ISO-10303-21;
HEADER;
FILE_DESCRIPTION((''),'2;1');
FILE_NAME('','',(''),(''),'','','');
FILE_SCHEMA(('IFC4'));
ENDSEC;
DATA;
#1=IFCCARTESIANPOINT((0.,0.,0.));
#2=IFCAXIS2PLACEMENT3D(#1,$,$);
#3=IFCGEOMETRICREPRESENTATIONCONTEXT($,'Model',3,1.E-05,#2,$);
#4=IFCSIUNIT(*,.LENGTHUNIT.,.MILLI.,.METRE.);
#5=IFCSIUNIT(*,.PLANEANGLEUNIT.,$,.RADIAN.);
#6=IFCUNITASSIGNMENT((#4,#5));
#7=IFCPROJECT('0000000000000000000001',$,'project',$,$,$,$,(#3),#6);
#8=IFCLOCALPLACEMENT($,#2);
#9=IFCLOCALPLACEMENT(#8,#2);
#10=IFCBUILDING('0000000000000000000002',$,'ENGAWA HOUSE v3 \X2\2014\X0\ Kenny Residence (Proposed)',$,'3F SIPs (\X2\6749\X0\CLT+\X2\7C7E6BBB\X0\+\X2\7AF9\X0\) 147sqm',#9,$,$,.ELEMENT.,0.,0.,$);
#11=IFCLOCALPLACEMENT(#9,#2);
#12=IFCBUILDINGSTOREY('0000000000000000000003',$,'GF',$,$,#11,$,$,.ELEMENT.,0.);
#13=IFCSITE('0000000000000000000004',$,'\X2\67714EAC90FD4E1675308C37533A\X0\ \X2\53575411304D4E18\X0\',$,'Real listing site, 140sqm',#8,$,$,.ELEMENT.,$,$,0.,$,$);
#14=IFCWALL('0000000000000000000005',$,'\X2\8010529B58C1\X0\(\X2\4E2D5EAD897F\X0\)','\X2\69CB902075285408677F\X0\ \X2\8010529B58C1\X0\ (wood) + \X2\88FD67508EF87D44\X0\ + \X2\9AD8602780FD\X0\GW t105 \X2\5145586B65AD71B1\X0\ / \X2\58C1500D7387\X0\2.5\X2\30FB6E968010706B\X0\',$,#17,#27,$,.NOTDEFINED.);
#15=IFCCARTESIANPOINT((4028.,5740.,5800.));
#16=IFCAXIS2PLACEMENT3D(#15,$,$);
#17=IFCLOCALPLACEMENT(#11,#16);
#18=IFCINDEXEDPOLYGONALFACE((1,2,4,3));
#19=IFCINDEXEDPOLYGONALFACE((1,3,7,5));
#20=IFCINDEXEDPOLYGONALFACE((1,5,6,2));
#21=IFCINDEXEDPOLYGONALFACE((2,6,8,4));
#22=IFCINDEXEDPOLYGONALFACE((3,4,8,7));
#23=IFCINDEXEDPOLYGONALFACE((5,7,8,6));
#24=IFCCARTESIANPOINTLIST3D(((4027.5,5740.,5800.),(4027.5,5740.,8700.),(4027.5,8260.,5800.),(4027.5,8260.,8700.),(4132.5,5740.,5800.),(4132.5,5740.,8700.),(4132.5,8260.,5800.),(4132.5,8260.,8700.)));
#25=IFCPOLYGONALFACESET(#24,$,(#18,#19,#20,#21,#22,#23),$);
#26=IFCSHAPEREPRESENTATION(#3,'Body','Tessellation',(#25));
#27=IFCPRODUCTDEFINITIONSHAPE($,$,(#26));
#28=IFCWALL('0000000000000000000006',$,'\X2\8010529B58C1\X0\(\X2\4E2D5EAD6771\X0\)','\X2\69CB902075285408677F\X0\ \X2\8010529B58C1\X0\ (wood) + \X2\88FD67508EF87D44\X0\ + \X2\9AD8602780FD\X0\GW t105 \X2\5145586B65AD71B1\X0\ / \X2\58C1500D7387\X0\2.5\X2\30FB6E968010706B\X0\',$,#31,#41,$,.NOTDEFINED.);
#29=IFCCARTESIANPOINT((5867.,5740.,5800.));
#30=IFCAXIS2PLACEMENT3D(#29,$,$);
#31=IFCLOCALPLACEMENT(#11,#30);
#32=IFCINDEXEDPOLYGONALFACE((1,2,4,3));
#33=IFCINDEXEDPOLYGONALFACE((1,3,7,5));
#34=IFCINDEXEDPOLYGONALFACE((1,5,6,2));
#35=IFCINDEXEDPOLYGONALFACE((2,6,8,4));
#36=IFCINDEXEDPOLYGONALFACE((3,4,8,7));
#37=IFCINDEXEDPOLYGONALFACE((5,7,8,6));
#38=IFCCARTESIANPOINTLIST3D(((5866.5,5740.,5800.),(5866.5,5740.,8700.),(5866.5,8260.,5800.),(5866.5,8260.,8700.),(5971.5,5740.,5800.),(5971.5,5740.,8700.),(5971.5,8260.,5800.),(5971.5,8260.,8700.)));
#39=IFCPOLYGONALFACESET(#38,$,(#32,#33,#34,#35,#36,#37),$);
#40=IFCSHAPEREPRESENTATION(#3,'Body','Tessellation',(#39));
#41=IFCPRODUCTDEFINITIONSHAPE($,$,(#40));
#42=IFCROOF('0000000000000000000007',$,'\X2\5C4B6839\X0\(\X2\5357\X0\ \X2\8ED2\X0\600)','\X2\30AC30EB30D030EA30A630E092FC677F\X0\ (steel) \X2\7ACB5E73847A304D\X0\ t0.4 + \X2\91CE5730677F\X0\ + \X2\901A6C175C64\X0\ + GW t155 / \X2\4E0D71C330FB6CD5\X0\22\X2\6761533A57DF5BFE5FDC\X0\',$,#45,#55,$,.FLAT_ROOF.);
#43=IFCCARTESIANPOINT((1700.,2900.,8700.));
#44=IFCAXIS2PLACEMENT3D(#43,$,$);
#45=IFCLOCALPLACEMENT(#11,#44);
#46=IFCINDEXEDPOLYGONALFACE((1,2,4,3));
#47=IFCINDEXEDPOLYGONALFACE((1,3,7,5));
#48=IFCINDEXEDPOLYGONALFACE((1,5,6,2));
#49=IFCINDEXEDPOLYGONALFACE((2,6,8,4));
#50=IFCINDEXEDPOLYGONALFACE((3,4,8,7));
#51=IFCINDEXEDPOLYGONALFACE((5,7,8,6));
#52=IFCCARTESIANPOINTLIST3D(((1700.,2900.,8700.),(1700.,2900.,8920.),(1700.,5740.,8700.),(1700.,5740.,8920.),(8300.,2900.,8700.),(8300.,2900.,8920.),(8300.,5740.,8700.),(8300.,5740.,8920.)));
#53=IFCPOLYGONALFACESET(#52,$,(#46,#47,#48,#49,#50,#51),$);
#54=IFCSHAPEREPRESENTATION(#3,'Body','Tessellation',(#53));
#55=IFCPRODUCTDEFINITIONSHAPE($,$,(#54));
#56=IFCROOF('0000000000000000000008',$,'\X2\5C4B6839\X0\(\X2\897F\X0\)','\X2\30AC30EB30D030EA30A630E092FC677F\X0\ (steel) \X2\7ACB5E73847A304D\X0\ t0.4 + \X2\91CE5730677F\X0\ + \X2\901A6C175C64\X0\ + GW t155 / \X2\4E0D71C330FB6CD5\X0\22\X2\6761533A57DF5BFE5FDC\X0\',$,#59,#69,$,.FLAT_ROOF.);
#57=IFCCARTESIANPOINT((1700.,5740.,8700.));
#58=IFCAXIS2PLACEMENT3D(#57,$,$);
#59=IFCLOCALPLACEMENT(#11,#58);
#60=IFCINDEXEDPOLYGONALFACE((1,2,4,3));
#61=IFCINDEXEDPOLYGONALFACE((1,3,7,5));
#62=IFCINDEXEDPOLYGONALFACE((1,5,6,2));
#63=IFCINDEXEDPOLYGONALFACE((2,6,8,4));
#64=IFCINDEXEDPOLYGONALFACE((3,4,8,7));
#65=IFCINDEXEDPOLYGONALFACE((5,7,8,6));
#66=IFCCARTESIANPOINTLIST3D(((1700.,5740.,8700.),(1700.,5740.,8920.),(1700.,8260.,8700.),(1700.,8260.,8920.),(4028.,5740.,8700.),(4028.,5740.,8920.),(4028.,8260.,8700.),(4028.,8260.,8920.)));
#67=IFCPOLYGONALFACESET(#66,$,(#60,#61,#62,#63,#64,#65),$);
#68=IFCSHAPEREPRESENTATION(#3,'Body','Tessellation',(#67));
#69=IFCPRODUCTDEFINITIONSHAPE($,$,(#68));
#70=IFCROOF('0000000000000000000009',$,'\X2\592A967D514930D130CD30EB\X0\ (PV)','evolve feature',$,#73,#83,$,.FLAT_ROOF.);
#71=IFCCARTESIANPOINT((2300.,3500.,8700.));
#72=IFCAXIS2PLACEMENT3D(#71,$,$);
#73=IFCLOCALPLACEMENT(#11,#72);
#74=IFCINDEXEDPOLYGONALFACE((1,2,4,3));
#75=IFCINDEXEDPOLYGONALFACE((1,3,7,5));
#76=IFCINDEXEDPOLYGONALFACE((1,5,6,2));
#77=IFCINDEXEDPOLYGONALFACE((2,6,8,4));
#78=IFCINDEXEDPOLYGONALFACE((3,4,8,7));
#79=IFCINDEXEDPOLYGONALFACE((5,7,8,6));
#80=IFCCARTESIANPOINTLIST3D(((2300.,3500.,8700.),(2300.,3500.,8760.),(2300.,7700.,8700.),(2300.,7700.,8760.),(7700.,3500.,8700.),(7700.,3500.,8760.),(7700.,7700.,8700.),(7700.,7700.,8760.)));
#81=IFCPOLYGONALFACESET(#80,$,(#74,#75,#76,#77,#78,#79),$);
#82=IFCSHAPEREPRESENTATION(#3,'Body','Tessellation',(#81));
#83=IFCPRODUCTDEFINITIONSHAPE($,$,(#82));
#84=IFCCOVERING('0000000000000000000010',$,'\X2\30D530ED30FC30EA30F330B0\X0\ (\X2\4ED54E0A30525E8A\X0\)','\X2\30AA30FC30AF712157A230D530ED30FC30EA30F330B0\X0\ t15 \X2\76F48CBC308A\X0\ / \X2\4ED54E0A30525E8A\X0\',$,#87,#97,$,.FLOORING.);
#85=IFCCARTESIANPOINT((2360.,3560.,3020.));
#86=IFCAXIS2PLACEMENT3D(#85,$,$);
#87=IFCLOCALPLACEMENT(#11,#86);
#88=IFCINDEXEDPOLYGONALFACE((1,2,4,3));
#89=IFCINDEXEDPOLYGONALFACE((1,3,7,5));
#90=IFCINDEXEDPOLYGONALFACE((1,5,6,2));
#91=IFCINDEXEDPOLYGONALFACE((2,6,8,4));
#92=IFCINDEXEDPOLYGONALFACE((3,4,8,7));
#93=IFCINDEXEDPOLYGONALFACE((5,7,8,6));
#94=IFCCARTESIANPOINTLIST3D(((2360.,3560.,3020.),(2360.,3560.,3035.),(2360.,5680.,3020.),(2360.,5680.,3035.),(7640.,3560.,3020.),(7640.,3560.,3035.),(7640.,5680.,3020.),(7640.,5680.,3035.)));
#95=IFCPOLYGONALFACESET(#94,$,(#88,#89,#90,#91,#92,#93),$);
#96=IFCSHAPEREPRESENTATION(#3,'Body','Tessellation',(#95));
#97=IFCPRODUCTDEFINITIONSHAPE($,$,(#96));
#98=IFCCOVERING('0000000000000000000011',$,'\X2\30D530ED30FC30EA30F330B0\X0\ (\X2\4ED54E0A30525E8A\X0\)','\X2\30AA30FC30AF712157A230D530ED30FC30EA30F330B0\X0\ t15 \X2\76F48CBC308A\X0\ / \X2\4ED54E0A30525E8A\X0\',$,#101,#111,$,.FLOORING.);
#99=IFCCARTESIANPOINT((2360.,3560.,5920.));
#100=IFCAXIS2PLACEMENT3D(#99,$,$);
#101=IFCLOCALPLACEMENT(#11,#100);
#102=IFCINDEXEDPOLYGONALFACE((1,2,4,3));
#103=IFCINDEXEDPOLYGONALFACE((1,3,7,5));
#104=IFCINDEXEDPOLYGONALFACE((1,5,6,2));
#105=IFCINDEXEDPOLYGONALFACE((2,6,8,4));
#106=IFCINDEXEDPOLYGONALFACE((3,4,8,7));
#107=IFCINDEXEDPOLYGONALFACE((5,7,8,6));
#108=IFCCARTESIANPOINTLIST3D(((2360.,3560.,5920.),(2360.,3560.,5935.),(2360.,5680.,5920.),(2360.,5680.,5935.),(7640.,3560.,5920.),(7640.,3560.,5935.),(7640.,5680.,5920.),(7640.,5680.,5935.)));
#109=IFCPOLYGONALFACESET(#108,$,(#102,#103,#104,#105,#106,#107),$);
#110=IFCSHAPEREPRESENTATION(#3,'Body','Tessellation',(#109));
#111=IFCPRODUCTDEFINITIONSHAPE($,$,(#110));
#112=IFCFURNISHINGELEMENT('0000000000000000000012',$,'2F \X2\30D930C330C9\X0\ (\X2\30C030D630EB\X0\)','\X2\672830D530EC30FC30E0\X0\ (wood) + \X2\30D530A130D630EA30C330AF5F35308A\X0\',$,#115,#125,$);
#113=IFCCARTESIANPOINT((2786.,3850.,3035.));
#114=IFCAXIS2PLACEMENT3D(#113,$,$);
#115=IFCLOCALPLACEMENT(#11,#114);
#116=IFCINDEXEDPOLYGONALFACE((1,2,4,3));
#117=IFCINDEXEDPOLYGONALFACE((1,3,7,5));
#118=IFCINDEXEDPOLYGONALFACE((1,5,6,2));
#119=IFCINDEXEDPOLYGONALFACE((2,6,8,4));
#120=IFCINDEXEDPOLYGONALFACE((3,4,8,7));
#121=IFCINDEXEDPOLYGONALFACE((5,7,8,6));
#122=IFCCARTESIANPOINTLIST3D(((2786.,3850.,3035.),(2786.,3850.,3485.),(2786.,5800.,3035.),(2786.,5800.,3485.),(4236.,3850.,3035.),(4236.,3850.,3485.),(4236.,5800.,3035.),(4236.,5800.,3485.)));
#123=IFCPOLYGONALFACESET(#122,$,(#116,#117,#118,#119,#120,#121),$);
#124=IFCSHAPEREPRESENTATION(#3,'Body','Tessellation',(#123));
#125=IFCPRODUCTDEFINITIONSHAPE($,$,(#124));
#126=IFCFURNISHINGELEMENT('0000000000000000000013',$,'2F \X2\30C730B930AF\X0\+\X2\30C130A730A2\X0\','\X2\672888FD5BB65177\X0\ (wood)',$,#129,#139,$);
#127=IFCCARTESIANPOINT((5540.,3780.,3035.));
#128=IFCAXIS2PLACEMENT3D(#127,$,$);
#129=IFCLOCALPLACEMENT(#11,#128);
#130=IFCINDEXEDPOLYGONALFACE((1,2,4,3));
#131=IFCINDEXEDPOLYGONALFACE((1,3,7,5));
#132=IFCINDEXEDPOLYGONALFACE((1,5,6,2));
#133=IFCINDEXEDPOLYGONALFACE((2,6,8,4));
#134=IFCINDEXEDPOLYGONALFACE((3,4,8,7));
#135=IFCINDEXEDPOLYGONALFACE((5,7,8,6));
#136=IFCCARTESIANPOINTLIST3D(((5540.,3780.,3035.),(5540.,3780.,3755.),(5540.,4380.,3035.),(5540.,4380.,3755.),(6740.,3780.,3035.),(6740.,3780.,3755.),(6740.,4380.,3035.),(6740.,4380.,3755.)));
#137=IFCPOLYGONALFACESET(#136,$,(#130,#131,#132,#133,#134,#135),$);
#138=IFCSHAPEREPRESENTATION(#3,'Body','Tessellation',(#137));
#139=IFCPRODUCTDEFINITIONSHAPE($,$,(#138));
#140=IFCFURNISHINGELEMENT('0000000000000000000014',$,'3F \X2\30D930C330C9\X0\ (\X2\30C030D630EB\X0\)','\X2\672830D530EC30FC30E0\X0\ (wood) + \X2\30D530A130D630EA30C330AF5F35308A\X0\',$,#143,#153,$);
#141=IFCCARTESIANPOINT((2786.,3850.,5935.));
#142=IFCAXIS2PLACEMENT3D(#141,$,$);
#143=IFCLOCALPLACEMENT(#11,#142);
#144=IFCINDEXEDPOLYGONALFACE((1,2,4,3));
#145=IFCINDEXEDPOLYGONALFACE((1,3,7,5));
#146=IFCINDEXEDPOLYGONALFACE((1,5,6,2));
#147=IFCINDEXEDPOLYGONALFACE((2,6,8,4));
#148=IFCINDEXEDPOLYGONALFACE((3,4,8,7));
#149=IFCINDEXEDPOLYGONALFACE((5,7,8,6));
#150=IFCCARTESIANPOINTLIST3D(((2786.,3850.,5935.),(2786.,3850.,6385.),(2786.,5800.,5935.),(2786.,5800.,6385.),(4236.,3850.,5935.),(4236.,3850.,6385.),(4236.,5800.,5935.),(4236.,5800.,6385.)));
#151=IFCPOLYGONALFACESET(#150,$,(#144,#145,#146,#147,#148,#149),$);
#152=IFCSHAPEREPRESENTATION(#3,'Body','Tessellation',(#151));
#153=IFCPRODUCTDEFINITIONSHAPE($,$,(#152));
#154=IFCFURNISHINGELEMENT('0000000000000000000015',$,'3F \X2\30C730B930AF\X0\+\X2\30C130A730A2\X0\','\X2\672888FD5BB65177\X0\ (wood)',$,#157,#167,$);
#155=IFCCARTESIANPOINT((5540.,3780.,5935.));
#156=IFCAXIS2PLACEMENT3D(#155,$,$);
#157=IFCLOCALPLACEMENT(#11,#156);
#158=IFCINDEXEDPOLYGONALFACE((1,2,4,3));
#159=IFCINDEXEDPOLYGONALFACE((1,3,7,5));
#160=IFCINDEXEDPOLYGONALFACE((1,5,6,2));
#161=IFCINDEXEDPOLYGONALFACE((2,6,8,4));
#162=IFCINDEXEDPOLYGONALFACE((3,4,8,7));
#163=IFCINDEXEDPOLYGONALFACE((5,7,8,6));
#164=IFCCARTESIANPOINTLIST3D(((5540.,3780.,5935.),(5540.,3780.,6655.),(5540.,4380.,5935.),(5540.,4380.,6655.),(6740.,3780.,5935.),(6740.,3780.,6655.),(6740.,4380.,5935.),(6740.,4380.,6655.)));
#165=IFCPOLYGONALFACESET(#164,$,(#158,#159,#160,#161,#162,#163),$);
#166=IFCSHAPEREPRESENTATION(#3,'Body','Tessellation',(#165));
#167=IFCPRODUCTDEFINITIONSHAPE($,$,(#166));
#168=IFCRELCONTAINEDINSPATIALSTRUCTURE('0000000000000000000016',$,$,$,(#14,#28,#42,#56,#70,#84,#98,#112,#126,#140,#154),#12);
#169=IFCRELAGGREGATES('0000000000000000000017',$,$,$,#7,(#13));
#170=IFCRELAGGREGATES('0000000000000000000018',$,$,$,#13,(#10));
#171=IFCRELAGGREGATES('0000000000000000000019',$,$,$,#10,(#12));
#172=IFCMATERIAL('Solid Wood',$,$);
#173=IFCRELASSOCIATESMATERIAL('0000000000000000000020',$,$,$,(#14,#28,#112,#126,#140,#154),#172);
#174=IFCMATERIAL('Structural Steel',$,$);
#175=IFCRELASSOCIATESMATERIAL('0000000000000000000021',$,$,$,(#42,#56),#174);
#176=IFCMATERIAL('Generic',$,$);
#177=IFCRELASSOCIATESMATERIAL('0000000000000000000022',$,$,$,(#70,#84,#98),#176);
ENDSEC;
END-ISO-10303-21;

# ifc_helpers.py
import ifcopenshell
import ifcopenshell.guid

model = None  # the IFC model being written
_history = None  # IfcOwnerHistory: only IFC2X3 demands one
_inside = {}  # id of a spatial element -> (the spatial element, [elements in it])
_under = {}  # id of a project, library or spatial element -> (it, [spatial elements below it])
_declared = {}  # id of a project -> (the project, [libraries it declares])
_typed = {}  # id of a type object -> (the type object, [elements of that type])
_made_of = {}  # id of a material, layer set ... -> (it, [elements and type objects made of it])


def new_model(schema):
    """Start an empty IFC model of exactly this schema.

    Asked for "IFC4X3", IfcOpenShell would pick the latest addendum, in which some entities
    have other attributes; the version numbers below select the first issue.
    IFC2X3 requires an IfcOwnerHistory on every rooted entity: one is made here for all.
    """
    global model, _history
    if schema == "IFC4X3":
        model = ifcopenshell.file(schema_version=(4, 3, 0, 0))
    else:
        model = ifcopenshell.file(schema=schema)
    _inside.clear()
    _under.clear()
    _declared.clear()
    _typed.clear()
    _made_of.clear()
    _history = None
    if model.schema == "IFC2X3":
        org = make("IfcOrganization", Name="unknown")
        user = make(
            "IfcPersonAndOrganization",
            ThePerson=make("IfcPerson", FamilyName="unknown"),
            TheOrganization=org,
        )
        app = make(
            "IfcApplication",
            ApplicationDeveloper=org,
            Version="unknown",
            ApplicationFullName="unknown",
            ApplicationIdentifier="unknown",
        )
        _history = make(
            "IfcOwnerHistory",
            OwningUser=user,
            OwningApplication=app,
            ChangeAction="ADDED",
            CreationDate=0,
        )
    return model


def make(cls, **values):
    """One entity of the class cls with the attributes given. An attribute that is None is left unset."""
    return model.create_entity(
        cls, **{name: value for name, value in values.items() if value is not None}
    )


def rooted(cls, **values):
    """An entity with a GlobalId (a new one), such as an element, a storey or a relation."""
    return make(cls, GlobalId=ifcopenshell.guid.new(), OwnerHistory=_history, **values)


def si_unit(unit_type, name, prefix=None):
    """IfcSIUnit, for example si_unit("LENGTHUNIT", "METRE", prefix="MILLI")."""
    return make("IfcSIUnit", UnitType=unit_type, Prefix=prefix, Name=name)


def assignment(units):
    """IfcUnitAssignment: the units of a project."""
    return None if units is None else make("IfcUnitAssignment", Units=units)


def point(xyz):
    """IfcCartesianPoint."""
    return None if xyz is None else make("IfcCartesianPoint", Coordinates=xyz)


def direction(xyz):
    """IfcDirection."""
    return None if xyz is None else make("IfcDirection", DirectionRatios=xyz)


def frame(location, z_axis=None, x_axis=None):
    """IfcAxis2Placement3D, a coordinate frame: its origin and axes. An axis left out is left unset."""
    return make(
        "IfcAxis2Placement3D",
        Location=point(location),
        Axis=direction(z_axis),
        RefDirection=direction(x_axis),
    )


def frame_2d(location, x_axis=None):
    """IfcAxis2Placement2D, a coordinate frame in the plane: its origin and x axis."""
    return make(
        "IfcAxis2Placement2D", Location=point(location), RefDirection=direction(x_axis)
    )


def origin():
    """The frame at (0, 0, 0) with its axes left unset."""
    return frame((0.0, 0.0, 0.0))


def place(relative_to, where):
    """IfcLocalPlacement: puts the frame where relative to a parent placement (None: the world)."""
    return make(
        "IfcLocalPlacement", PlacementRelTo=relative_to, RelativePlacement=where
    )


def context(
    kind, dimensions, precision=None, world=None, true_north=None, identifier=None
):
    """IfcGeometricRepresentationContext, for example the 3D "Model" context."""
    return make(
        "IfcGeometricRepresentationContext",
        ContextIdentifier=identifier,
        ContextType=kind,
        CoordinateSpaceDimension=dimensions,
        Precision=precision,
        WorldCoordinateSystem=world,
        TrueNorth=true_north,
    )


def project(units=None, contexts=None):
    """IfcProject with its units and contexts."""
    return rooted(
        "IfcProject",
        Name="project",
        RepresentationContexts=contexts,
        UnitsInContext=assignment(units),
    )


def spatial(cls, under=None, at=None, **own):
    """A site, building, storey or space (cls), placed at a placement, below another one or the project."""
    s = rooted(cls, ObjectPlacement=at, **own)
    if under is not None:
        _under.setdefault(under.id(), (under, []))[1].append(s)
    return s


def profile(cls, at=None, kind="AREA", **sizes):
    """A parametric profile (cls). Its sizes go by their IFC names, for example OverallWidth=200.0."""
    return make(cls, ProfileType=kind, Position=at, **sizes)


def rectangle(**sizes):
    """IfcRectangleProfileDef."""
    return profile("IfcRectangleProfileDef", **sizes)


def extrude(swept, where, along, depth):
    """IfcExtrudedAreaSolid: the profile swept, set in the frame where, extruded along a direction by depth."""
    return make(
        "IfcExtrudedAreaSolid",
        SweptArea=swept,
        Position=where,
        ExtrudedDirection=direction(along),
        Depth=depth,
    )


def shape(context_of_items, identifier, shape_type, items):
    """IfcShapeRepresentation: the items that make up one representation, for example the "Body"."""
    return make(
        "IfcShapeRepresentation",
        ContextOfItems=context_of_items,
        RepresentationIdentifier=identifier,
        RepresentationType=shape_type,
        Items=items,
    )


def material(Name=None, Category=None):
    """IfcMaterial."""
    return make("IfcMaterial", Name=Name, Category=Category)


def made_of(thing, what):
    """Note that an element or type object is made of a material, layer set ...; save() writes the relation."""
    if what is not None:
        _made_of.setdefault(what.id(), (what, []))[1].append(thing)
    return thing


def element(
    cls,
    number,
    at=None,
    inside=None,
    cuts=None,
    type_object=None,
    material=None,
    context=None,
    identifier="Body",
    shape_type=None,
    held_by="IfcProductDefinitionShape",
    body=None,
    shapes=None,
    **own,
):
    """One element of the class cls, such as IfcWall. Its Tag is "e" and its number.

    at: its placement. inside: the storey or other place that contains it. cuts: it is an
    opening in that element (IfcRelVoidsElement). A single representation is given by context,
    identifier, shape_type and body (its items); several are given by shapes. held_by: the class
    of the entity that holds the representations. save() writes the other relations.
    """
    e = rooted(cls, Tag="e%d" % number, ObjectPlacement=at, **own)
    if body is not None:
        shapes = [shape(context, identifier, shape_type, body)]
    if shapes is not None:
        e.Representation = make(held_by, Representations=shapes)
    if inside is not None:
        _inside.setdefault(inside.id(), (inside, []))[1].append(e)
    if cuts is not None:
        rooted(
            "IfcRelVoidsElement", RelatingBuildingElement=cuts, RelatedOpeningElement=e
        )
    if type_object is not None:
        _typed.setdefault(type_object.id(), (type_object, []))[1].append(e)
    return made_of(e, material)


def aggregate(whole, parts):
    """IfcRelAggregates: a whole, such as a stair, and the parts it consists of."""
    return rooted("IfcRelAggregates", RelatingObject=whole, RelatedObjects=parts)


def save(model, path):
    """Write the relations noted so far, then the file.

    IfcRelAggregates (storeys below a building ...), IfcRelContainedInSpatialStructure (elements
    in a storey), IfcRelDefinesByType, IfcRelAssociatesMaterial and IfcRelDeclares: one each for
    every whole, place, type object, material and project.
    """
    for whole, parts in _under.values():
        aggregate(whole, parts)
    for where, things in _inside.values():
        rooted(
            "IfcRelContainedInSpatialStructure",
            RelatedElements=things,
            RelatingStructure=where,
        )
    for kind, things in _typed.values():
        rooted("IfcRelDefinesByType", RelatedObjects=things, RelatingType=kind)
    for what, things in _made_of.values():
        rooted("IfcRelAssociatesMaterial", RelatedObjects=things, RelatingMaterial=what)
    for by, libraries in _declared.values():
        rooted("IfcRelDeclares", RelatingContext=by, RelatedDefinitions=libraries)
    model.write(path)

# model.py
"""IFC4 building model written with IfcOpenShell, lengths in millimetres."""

from ifc_helpers import new_model, si_unit, frame, frame_2d, origin, place, context, project, spatial, rectangle, extrude, material, element, save


model = new_model("IFC4")

# Units and contexts
model_context = context("Model", 3, precision=1e-05, world=origin())
ifc_project = project(units=[si_unit("LENGTHUNIT", "METRE", prefix="MILLI"), si_unit("PLANEANGLEUNIT", "RADIAN")], contexts=[model_context])

# Site, building, storey
site_placement = place(None, origin())
site = spatial("IfcSite", under=ifc_project, at=site_placement, Name="東京都世田谷区 南向き丘", ObjectType="Real listing site, 140sqm", CompositionType="ELEMENT", RefElevation=0.0)
building_placement = place(site_placement, origin())
building = spatial("IfcBuilding", under=site, at=building_placement, Name="ENGAWA HOUSE v3 — Kenny Residence (Proposed)", ObjectType="3F SIPs (杉CLT+籾殻+竹) 147sqm", CompositionType="ELEMENT", ElevationOfRefHeight=0.0, ElevationOfTerrain=0.0)
storey_placement = place(building_placement, origin())
storey = spatial("IfcBuildingStorey", under=building, at=storey_placement, Name="GF", CompositionType="ELEMENT", Elevation=0.0)

# Shared definitions
ifc_material_1 = material(Name="Solid Wood")

# Walls
wall_1_placement = place(storey_placement, frame((4028.0, 5740.0, 5800.0)))
element("IfcWall", 1, at=wall_1_placement, inside=storey, material=ifc_material_1, Name="耐力壁(中庭西)", Description="構造用合板 耐力壁 (wood) + 製材軸組 + 高性能GW t105 充填断熱 / 壁倍率2.5・準耐火", PredefinedType="NOTDEFINED", context=model_context, shape_type="SweptSolid", body=[
    extrude(rectangle(XDim=105.0, YDim=2520.0, at=frame_2d((52.0, 1260.0))), frame((4028.0, 5740.0, 5800.0)), (0.0, 0.0, 1.0), 2900.0),
])
wall_2_placement = place(storey_placement, frame((5867.0, 5740.0, 5800.0)))
element("IfcWall", 2, at=wall_2_placement, inside=storey, material=ifc_material_1, Name="耐力壁(中庭東)", Description="構造用合板 耐力壁 (wood) + 製材軸組 + 高性能GW t105 充填断熱 / 壁倍率2.5・準耐火", PredefinedType="NOTDEFINED", context=model_context, shape_type="SweptSolid", body=[
    extrude(rectangle(XDim=105.0, YDim=2520.0, at=frame_2d((52.0, 1260.0))), frame((5867.0, 5740.0, 5800.0)), (0.0, 0.0, 1.0), 2900.0),
])

# Roofs
ifc_material_2 = material(Name="Structural Steel")
roof_1_placement = place(storey_placement, frame((1700.0, 2900.0, 8700.0)))
element("IfcRoof", 3, at=roof_1_placement, inside=storey, material=ifc_material_2, Name="屋根(南 軒600)", Description="ガルバリウム鋼板 (steel) 立平葺き t0.4 + 野地板 + 通気層 + GW t155 / 不燃・法22条区域対応", PredefinedType="FLAT_ROOF", context=model_context, shape_type="SweptSolid", body=[
    extrude(rectangle(XDim=6600.0, YDim=2840.0, at=frame_2d((3300.0, 1420.0))), frame((1700.0, 2900.0, 8700.0)), (0.0, 0.0, 1.0), 220.0),
])
roof_2_placement = place(storey_placement, frame((1700.0, 5740.0, 8700.0)))
element("IfcRoof", 4, at=roof_2_placement, inside=storey, material=ifc_material_2, Name="屋根(西)", Description="ガルバリウム鋼板 (steel) 立平葺き t0.4 + 野地板 + 通気層 + GW t155 / 不燃・法22条区域対応", PredefinedType="FLAT_ROOF", context=model_context, shape_type="SweptSolid", body=[
    extrude(rectangle(XDim=2328.0, YDim=2520.0, at=frame_2d((1164.0, 1260.0))), frame((1700.0, 5740.0, 8700.0)), (0.0, 0.0, 1.0), 220.0),
])
ifc_material_3 = material(Name="Generic")
roof_3_placement = place(storey_placement, frame((2300.0, 3500.0, 8700.0)))
element("IfcRoof", 5, at=roof_3_placement, inside=storey, material=ifc_material_3, Name="太陽光パネル (PV)", Description="evolve feature", PredefinedType="FLAT_ROOF", context=model_context, shape_type="SweptSolid", body=[
    extrude(rectangle(XDim=5400.0, YDim=4200.0, at=frame_2d((2700.0, 2100.0))), frame((2300.0, 3500.0, 8700.0)), (0.0, 0.0, 1.0), 60.0),
])

# Coverings
covering_1_placement = place(storey_placement, frame((2360.0, 3560.0, 3020.0)))
element("IfcCovering", 6, at=covering_1_placement, inside=storey, material=ifc_material_3, Name="フローリング (仕上げ床)", Description="オーク無垢フローリング t15 直貼り / 仕上げ床", PredefinedType="FLOORING", context=model_context, shape_type="SweptSolid", body=[
    extrude(rectangle(XDim=5280.0, YDim=2120.0, at=frame_2d((2640.0, 1060.0))), frame((2360.0, 3560.0, 3020.0)), (0.0, 0.0, 1.0), 15.0),
])
covering_2_placement = place(storey_placement, frame((2360.0, 3560.0, 5920.0)))
element("IfcCovering", 7, at=covering_2_placement, inside=storey, material=ifc_material_3, Name="フローリング (仕上げ床)", Description="オーク無垢フローリング t15 直貼り / 仕上げ床", PredefinedType="FLOORING", context=model_context, shape_type="SweptSolid", body=[
    extrude(rectangle(XDim=5280.0, YDim=2120.0, at=frame_2d((2640.0, 1060.0))), frame((2360.0, 3560.0, 5920.0)), (0.0, 0.0, 1.0), 15.0),
])

# Furnishing elements
furnishing_1_placement = place(storey_placement, frame((2786.0, 3850.0, 3035.0)))
element("IfcFurnishingElement", 8, at=furnishing_1_placement, inside=storey, material=ifc_material_1, Name="2F ベッド (ダブル)", Description="木フレーム (wood) + ファブリック張り", context=model_context, shape_type="SweptSolid", body=[
    extrude(rectangle(XDim=1450.0, YDim=1950.0, at=frame_2d((725.0, 975.0))), frame((2786.0, 3850.0, 3035.0)), (0.0, 0.0, 1.0), 450.0),
])
furnishing_2_placement = place(storey_placement, frame((5540.0, 3780.0, 3035.0)))
element("IfcFurnishingElement", 9, at=furnishing_2_placement, inside=storey, material=ifc_material_1, Name="2F デスク+チェア", Description="木製家具 (wood)", context=model_context, shape_type="SweptSolid", body=[
    extrude(rectangle(XDim=1200.0, YDim=600.0, at=frame_2d((600.0, 300.0))), frame((5540.0, 3780.0, 3035.0)), (0.0, 0.0, 1.0), 720.0),
])
furnishing_3_placement = place(storey_placement, frame((2786.0, 3850.0, 5935.0)))
element("IfcFurnishingElement", 10, at=furnishing_3_placement, inside=storey, material=ifc_material_1, Name="3F ベッド (ダブル)", Description="木フレーム (wood) + ファブリック張り", context=model_context, shape_type="SweptSolid", body=[
    extrude(rectangle(XDim=1450.0, YDim=1950.0, at=frame_2d((725.0, 975.0))), frame((2786.0, 3850.0, 5935.0)), (0.0, 0.0, 1.0), 450.0),
])
furnishing_4_placement = place(storey_placement, frame((5540.0, 3780.0, 5935.0)))
element("IfcFurnishingElement", 11, at=furnishing_4_placement, inside=storey, material=ifc_material_1, Name="3F デスク+チェア", Description="木製家具 (wood)", context=model_context, shape_type="SweptSolid", body=[
    extrude(rectangle(XDim=1200.0, YDim=600.0, at=frame_2d((600.0, 300.0))), frame((5540.0, 3780.0, 5935.0)), (0.0, 0.0, 1.0), 720.0),
])

save(model, "model.ifc")
